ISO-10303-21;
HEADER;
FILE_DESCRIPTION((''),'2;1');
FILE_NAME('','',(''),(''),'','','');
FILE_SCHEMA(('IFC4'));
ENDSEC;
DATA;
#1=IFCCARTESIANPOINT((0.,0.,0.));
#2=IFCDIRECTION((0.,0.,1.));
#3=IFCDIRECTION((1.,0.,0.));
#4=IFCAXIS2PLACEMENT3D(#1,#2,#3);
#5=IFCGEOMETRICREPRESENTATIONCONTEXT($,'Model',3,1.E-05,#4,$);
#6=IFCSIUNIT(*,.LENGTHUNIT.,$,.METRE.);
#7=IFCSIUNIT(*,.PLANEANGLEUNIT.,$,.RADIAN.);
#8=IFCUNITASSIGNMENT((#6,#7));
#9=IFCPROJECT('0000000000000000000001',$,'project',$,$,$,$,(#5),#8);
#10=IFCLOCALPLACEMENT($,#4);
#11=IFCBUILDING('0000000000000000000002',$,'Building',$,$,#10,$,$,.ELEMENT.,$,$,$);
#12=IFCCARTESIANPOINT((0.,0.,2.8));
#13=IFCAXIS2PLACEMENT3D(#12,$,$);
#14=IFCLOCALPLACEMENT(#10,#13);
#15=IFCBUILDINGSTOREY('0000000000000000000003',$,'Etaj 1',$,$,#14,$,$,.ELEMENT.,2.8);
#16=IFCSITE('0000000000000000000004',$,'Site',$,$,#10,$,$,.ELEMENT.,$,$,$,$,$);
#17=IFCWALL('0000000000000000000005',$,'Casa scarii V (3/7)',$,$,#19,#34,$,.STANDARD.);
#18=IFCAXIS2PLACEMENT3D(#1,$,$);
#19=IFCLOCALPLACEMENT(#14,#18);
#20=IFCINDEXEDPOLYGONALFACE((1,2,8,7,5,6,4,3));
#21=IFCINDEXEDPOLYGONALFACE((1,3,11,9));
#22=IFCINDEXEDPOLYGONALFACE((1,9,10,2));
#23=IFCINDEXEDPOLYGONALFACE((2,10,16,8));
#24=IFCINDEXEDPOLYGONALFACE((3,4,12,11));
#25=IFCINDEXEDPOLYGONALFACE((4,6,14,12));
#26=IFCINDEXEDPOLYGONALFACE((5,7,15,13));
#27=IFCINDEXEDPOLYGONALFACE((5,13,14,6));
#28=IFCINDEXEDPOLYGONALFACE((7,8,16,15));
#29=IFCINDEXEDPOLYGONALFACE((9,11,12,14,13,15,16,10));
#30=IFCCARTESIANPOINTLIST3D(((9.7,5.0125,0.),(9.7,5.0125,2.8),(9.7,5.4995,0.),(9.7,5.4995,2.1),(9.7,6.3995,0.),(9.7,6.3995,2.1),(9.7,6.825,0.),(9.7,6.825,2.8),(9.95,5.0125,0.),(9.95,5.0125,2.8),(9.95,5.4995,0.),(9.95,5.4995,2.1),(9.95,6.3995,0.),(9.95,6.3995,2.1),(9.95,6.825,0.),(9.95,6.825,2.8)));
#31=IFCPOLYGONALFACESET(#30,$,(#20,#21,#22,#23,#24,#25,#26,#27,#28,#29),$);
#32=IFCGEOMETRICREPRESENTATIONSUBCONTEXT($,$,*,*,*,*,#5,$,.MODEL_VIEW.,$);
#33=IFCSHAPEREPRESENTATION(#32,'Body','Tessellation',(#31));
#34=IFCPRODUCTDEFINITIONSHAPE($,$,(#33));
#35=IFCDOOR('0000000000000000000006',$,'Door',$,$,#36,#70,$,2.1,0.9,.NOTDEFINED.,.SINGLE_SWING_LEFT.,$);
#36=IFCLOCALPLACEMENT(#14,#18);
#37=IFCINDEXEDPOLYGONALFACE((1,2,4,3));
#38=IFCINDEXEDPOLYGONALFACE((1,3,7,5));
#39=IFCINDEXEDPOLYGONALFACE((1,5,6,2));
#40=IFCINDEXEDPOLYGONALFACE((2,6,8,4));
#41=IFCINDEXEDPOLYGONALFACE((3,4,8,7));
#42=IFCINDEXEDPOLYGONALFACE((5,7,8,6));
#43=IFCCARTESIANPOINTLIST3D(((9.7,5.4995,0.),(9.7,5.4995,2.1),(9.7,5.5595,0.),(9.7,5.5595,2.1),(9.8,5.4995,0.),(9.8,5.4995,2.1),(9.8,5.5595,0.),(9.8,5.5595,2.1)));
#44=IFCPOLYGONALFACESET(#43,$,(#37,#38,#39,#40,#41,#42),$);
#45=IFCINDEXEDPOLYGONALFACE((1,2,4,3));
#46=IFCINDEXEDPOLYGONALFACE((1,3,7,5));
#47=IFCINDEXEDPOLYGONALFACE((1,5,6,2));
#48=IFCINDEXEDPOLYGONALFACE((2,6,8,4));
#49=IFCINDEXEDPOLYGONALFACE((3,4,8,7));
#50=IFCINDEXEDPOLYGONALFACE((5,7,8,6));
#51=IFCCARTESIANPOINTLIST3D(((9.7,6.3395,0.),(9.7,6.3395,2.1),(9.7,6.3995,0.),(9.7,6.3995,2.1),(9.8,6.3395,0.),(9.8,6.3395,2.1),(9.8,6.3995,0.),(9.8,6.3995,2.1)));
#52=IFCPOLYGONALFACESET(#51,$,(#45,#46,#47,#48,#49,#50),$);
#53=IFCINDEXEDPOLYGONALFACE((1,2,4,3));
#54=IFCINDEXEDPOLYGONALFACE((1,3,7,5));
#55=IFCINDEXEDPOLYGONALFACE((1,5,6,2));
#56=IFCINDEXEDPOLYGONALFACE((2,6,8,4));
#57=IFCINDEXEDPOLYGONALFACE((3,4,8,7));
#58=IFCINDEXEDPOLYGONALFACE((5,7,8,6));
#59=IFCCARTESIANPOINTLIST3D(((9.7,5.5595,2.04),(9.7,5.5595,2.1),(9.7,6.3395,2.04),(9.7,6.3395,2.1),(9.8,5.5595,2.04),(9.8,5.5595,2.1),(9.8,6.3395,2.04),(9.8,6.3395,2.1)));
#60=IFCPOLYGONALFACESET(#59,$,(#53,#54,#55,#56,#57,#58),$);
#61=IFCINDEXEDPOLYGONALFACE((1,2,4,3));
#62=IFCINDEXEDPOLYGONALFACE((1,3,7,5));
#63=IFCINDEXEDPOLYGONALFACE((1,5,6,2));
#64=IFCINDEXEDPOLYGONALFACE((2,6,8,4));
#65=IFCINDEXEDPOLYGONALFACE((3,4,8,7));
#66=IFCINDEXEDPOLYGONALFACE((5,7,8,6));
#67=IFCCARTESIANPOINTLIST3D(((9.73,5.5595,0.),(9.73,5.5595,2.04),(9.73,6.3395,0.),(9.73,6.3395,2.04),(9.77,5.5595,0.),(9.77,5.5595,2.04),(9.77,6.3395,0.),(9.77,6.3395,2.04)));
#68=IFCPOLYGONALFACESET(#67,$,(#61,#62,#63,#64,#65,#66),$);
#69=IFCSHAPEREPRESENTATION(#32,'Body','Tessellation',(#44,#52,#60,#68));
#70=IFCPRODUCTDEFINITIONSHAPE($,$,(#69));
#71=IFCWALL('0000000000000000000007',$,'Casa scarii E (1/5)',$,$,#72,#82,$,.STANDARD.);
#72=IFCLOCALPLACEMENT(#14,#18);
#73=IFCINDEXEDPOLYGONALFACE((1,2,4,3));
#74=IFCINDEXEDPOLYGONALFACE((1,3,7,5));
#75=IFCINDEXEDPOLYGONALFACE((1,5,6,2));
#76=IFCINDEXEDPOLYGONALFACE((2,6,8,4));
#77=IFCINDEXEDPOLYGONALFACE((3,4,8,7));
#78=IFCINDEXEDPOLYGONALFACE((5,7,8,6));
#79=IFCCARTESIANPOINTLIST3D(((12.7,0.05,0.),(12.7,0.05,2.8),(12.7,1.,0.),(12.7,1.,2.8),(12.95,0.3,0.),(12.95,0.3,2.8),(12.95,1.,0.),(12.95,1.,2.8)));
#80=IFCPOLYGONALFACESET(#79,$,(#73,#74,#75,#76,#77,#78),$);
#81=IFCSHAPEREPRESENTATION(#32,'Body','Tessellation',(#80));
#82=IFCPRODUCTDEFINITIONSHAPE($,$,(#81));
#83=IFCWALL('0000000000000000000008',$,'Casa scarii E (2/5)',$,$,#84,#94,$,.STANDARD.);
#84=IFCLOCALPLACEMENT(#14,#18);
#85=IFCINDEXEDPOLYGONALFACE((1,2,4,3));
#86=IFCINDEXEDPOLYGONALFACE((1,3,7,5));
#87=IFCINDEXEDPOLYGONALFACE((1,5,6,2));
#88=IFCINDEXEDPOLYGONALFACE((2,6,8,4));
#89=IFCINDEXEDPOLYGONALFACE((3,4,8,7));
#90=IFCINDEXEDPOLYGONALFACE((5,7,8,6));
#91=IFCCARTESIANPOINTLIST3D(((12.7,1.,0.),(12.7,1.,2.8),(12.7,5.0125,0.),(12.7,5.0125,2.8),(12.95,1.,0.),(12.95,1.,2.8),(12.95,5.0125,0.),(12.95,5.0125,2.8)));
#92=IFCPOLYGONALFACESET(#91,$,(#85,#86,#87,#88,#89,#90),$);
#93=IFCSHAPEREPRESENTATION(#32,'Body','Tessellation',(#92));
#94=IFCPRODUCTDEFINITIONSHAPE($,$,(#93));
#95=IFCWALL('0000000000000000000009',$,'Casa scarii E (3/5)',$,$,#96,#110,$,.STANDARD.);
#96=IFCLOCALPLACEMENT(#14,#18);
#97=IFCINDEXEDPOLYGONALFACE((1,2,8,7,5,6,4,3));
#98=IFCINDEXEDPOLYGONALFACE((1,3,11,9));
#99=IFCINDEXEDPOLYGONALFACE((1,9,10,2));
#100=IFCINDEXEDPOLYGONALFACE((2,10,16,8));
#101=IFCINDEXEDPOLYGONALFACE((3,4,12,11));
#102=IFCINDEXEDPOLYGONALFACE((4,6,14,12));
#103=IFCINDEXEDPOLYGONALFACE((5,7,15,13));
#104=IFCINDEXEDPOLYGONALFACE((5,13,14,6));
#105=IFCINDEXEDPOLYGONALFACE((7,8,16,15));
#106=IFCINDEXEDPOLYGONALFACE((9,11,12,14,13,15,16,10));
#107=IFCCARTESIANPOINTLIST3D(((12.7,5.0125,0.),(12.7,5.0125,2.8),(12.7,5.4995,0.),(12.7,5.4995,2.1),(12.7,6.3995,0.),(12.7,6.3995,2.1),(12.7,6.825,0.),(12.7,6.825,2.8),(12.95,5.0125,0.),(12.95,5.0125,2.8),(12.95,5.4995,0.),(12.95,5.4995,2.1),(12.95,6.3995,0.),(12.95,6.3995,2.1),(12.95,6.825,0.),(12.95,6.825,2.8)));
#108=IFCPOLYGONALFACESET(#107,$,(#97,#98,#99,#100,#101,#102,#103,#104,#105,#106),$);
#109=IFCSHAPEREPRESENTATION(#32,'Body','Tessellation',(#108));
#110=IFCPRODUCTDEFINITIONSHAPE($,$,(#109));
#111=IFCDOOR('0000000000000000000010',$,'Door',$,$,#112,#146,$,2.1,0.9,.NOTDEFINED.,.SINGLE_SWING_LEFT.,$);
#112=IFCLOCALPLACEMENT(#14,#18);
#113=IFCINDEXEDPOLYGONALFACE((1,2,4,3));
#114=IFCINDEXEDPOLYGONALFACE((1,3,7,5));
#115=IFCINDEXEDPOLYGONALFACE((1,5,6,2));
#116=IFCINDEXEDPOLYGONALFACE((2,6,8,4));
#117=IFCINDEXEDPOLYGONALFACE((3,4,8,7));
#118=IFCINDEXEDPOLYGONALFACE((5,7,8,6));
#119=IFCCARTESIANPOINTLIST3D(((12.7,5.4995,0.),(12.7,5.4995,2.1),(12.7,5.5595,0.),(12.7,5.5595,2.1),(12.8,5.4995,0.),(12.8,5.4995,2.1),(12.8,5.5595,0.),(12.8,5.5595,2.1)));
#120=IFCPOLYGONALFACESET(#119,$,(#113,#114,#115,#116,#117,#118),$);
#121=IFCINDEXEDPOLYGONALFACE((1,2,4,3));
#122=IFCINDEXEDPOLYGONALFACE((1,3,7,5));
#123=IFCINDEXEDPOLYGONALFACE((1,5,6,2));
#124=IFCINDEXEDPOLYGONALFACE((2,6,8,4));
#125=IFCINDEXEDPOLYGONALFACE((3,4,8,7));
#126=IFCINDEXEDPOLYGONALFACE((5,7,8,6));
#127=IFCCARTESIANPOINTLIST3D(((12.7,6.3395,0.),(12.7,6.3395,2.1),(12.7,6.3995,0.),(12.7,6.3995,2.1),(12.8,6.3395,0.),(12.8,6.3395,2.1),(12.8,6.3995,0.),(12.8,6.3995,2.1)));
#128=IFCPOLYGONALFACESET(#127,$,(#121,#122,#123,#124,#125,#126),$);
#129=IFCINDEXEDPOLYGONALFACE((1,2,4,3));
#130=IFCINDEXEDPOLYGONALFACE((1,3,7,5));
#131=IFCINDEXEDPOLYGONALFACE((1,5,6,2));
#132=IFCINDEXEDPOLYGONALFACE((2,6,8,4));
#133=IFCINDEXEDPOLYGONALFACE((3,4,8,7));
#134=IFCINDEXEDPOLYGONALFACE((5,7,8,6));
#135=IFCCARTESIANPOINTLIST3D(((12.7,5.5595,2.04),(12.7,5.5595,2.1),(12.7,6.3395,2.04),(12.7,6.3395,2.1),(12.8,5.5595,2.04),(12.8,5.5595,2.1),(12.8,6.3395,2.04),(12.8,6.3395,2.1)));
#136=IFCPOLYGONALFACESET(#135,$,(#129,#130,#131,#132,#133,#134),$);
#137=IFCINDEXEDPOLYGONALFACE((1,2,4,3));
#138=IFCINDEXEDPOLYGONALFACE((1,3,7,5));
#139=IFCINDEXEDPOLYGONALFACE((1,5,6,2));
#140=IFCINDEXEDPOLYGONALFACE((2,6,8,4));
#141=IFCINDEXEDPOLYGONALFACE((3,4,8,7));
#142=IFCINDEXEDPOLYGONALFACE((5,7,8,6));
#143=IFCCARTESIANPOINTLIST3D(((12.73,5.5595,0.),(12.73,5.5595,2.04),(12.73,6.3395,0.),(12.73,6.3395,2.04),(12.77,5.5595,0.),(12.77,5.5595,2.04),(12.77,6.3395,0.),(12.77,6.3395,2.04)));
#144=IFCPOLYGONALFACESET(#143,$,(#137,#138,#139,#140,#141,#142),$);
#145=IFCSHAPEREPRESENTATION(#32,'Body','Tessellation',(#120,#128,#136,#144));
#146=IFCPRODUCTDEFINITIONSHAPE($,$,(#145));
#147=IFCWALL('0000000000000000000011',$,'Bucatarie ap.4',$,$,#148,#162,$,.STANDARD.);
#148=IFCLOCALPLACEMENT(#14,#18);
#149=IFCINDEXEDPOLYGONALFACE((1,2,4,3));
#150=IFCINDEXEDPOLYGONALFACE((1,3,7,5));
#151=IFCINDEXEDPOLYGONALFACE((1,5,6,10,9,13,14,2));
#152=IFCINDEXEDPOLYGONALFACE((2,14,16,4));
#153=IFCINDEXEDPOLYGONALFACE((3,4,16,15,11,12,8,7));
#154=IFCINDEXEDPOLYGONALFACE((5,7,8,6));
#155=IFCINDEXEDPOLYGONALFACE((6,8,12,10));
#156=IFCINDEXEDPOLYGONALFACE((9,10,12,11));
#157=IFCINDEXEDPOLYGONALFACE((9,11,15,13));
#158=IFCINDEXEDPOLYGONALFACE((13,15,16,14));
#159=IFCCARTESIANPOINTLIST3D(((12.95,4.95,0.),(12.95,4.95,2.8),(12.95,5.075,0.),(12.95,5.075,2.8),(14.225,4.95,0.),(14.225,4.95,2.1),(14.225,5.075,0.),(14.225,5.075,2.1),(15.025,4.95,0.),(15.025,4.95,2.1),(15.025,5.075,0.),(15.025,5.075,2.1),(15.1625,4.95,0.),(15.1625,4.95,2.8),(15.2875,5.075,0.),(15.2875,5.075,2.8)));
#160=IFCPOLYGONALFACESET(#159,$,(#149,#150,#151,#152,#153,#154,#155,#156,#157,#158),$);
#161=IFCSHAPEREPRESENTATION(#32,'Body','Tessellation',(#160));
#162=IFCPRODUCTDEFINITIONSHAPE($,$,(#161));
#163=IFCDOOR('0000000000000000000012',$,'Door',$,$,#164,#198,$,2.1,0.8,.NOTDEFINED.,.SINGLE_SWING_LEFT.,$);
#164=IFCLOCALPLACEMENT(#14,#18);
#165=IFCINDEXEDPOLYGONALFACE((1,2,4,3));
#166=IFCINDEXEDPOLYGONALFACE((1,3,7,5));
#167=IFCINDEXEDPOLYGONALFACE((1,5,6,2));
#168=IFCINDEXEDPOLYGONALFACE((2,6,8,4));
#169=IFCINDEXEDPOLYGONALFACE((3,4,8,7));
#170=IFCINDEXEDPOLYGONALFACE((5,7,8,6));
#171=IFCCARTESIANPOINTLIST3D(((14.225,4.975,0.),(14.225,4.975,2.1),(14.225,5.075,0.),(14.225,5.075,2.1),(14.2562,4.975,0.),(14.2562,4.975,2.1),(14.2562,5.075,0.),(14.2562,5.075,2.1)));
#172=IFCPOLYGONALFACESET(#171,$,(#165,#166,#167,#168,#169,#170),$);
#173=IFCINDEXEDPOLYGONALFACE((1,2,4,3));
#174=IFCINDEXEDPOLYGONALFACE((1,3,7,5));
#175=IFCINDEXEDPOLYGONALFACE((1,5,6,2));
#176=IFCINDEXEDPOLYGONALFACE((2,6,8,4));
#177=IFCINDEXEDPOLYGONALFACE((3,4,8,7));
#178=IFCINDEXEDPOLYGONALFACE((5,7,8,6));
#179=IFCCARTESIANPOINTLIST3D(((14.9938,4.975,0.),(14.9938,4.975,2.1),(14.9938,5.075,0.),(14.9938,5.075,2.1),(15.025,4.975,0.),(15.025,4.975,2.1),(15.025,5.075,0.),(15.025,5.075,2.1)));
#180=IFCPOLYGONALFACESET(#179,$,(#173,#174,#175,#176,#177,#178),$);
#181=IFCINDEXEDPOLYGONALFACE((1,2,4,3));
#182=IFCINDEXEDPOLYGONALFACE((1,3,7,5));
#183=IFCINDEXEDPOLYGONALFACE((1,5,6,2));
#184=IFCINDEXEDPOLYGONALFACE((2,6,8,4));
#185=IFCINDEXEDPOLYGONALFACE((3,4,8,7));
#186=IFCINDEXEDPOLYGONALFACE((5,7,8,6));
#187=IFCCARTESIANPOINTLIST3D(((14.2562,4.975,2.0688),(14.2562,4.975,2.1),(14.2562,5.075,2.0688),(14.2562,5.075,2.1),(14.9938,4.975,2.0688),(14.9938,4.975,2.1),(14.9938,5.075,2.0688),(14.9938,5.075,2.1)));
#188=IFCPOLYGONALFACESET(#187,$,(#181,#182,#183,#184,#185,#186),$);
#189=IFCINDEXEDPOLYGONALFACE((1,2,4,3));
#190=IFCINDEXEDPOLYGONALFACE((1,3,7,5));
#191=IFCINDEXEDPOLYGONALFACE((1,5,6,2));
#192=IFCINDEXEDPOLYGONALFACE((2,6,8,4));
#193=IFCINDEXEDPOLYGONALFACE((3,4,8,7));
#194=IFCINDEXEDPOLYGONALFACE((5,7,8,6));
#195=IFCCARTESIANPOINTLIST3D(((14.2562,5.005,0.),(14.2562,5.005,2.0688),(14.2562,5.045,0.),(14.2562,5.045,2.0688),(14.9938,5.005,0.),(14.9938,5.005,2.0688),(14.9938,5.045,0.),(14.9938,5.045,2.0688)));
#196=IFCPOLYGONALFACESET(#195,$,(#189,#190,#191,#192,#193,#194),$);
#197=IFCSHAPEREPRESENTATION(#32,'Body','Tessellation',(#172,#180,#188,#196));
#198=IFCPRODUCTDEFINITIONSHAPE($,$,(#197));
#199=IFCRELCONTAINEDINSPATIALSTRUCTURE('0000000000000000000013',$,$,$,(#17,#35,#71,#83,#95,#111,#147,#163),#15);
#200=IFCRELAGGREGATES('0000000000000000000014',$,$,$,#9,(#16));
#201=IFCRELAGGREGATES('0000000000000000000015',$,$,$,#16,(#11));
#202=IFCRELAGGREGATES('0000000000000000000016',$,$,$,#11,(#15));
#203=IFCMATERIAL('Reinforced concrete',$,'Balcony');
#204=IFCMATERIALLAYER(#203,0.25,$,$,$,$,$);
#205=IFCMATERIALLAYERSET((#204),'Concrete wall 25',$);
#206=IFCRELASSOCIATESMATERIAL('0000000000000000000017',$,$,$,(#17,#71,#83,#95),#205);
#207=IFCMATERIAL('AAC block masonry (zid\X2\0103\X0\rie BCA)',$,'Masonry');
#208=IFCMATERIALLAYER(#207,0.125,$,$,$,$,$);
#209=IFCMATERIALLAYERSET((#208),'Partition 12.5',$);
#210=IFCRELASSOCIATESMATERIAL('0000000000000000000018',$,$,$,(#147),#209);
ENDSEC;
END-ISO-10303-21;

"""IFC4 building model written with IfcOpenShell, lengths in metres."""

from ifc_helpers import new_model, si_unit, frame, frame_2d, origin, origin_with_axes, origin_2d, place, context, subcontext, project, spatial, rectangle, extrude, clip, halfspace, material, layer, layer_set, layer_usage, element, fill, save


model = new_model("IFC4")

# Units and contexts
model_context = context("Model", 3, precision=1e-05, world=origin_with_axes())
sub_context = subcontext(model_context, None, None, "MODEL_VIEW")
ifc_project = project(units=[si_unit("LENGTHUNIT", "METRE"), si_unit("PLANEANGLEUNIT", "RADIAN")], contexts=[model_context])

# Site, building, storey
placement = place(None, origin_with_axes())
site = spatial("IfcSite", under=ifc_project, at=placement, Name="Site", CompositionType="ELEMENT")
building = spatial("IfcBuilding", under=site, at=placement, Name="Building", CompositionType="ELEMENT")
storey_placement = place(placement, frame((0.0, 0.0, 2.8)))
storey = spatial("IfcBuildingStorey", under=building, at=storey_placement, Name="Etaj 1", CompositionType="ELEMENT", Elevation=2.8)

# Shared definitions
ifc_material_1 = material(Name="Reinforced concrete", Category="Balcony")

# Shared definitions
ifc_layer_1 = layer(ifc_material_1, 0.25)
ifc_layer_set_1 = layer_set([ifc_layer_1], Name="Concrete wall 25")
ifc_layer_usage_1 = layer_usage(ifc_layer_set_1, "AXIS2", "POSITIVE", -0.125)

# Wall, opening, door
wall_1_placement = place(storey_placement, frame((9.825, 5.0125, 0.0), x_axis=(0.0, 1.0, 0.0)))
wall_1 = element("IfcWall", 1, at=wall_1_placement, inside=storey, material=ifc_layer_usage_1, Name="Casa scarii V (3/7)", PredefinedType="STANDARD", context=sub_context, shape_type="SweptSolid", body=[
    extrude(rectangle(XDim=1.8125, YDim=0.25, at=frame_2d((0.9062, 0.0))), origin(), (0.0, 0.0, 1.0), 2.8),
])
opening_1_placement = place(wall_1_placement, frame((0.937, 0.175, 0.0), z_axis=(0.0, -1.0, 0.0), x_axis=(1.0, 0.0, 0.0)))
opening_1 = element("IfcOpeningElement", 2, at=opening_1_placement, cuts=wall_1, PredefinedType="OPENING", context=sub_context, shape_type="SweptSolid", body=[
    extrude(rectangle(XDim=0.9, YDim=2.1, at=frame_2d((0.0, 1.05))), origin(), (0.0, 0.0, 1.0), 0.35),
])
door_1_placement = place(wall_1_placement, frame((0.937, 0.125, 0.0), z_axis=(0.0, -1.0, 0.0), x_axis=(1.0, 0.0, 0.0)))
door_1 = element("IfcDoor", 3, at=door_1_placement, inside=storey, Name="Door", OperationType="SINGLE_SWING_LEFT", OverallHeight=2.1, OverallWidth=0.9, PredefinedType="NOTDEFINED", context=sub_context, shape_type="SweptSolid", body=[
    extrude(rectangle(XDim=0.06, YDim=2.1, at=origin_2d()), frame((-0.42, 1.05, 0.0)), (0.0, 0.0, 1.0), 0.1),
    extrude(rectangle(XDim=0.06, YDim=2.1, at=origin_2d()), frame((0.42, 1.05, 0.0)), (0.0, 0.0, 1.0), 0.1),
    extrude(rectangle(XDim=0.78, YDim=0.06, at=origin_2d()), frame((0.0, 2.07, 0.0)), (0.0, 0.0, 1.0), 0.1),
    extrude(rectangle(XDim=0.78, YDim=2.04, at=origin_2d()), frame((0.0, 1.02, 0.03)), (0.0, 0.0, 1.0), 0.04),
])
fill(opening_1, door_1)

# Walls
wall_2_placement = place(storey_placement, frame((12.825, 0.05, 0.0), x_axis=(0.0, 1.0, 0.0)))
element("IfcWall", 4, at=wall_2_placement, inside=storey, material=ifc_layer_usage_1, Name="Casa scarii E (1/5)", PredefinedType="STANDARD", context=sub_context, shape_type="CSG", body=[
    clip(extrude(rectangle(XDim=0.95, YDim=0.25, at=frame_2d((0.475, 0.0))), origin(), (0.0, 0.0, 1.0), 2.8), halfspace(frame((0.125, 0.0, 0.0), z_axis=(-0.707107, -0.707107, 0.0)), False)),
])
wall_3_placement = place(storey_placement, frame((12.825, 1.0, 0.0), x_axis=(0.0, 1.0, 0.0)))
element("IfcWall", 5, at=wall_3_placement, inside=storey, material=ifc_layer_usage_1, Name="Casa scarii E (2/5)", PredefinedType="STANDARD", context=sub_context, shape_type="SweptSolid", body=[
    extrude(rectangle(XDim=4.0125, YDim=0.25, at=frame_2d((2.0063, 0.0))), origin(), (0.0, 0.0, 1.0), 2.8),
])

# Walls, openings, doors
wall_4_placement = place(storey_placement, frame((12.825, 5.0125, 0.0), x_axis=(0.0, 1.0, 0.0)))
wall_4 = element("IfcWall", 6, at=wall_4_placement, inside=storey, material=ifc_layer_usage_1, Name="Casa scarii E (3/5)", PredefinedType="STANDARD", context=sub_context, shape_type="SweptSolid", body=[
    extrude(rectangle(XDim=1.8125, YDim=0.25, at=frame_2d((0.9062, 0.0))), origin(), (0.0, 0.0, 1.0), 2.8),
])
opening_2_placement = place(wall_4_placement, frame((0.937, 0.175, 0.0), z_axis=(0.0, -1.0, 0.0), x_axis=(1.0, 0.0, 0.0)))
opening_2 = element("IfcOpeningElement", 7, at=opening_2_placement, cuts=wall_4, PredefinedType="OPENING", context=sub_context, shape_type="SweptSolid", body=[
    extrude(rectangle(XDim=0.9, YDim=2.1, at=frame_2d((0.0, 1.05))), origin(), (0.0, 0.0, 1.0), 0.35),
])
door_2_placement = place(wall_4_placement, frame((0.937, 0.125, 0.0), z_axis=(0.0, -1.0, 0.0), x_axis=(1.0, 0.0, 0.0)))
door_2 = element("IfcDoor", 8, at=door_2_placement, inside=storey, Name="Door", OperationType="SINGLE_SWING_LEFT", OverallHeight=2.1, OverallWidth=0.9, PredefinedType="NOTDEFINED", context=sub_context, shape_type="SweptSolid", body=[
    extrude(rectangle(XDim=0.06, YDim=2.1, at=origin_2d()), frame((-0.42, 1.05, 0.0)), (0.0, 0.0, 1.0), 0.1),
    extrude(rectangle(XDim=0.06, YDim=2.1, at=origin_2d()), frame((0.42, 1.05, 0.0)), (0.0, 0.0, 1.0), 0.1),
    extrude(rectangle(XDim=0.78, YDim=0.06, at=origin_2d()), frame((0.0, 2.07, 0.0)), (0.0, 0.0, 1.0), 0.1),
    extrude(rectangle(XDim=0.78, YDim=2.04, at=origin_2d()), frame((0.0, 1.02, 0.03)), (0.0, 0.0, 1.0), 0.04),
])
fill(opening_2, door_2)
ifc_material_2 = material(Name="AAC block masonry (zidărie BCA)", Category="Masonry")
ifc_layer_2 = layer(ifc_material_2, 0.125)
ifc_layer_set_2 = layer_set([ifc_layer_2], Name="Partition 12.5")
ifc_layer_usage_2 = layer_usage(ifc_layer_set_2, "AXIS2", "POSITIVE", -0.0625)
wall_5_placement = place(storey_placement, frame((12.95, 5.0125, 0.0), x_axis=(1.0, 0.0, 0.0)))
wall_5 = element("IfcWall", 9, at=wall_5_placement, inside=storey, material=ifc_layer_usage_2, Name="Bucatarie ap.4", PredefinedType="STANDARD", context=sub_context, shape_type="CSG", body=[
    clip(extrude(rectangle(XDim=2.3375, YDim=0.125, at=frame_2d((1.1687, 0.0))), origin(), (0.0, 0.0, 1.0), 2.8), halfspace(frame((2.275, 0.0, 0.0), z_axis=(0.707107, -0.707107, 0.0)), False)),
])
opening_3_placement = place(wall_5_placement, frame((1.675, 0.1125, 0.0), z_axis=(0.0, -1.0, 0.0), x_axis=(1.0, 0.0, 0.0)))
opening_3 = element("IfcOpeningElement", 10, at=opening_3_placement, cuts=wall_5, PredefinedType="OPENING", context=sub_context, shape_type="SweptSolid", body=[
    extrude(rectangle(XDim=0.8, YDim=2.1, at=frame_2d((0.0, 1.05))), origin(), (0.0, 0.0, 1.0), 0.225),
])
door_3_placement = place(wall_5_placement, frame((1.675, 0.0625, 0.0), z_axis=(0.0, -1.0, 0.0), x_axis=(1.0, 0.0, 0.0)))
door_3 = element("IfcDoor", 11, at=door_3_placement, inside=storey, Name="Door", OperationType="SINGLE_SWING_LEFT", OverallHeight=2.1, OverallWidth=0.8, PredefinedType="NOTDEFINED", context=sub_context, shape_type="SweptSolid", body=[
    extrude(rectangle(XDim=0.0312, YDim=2.1, at=origin_2d()), frame((-0.3844, 1.05, 0.0)), (0.0, 0.0, 1.0), 0.1),
    extrude(rectangle(XDim=0.0312, YDim=2.1, at=origin_2d()), frame((0.3844, 1.05, 0.0)), (0.0, 0.0, 1.0), 0.1),
    extrude(rectangle(XDim=0.7375, YDim=0.0312, at=origin_2d()), frame((0.0, 2.0844, 0.0)), (0.0, 0.0, 1.0), 0.1),
    extrude(rectangle(XDim=0.7375, YDim=2.0688, at=origin_2d()), frame((0.0, 1.0344, 0.03)), (0.0, 0.0, 1.0), 0.04),
])
fill(opening_3, door_3)

save(model, "model.ifc")
